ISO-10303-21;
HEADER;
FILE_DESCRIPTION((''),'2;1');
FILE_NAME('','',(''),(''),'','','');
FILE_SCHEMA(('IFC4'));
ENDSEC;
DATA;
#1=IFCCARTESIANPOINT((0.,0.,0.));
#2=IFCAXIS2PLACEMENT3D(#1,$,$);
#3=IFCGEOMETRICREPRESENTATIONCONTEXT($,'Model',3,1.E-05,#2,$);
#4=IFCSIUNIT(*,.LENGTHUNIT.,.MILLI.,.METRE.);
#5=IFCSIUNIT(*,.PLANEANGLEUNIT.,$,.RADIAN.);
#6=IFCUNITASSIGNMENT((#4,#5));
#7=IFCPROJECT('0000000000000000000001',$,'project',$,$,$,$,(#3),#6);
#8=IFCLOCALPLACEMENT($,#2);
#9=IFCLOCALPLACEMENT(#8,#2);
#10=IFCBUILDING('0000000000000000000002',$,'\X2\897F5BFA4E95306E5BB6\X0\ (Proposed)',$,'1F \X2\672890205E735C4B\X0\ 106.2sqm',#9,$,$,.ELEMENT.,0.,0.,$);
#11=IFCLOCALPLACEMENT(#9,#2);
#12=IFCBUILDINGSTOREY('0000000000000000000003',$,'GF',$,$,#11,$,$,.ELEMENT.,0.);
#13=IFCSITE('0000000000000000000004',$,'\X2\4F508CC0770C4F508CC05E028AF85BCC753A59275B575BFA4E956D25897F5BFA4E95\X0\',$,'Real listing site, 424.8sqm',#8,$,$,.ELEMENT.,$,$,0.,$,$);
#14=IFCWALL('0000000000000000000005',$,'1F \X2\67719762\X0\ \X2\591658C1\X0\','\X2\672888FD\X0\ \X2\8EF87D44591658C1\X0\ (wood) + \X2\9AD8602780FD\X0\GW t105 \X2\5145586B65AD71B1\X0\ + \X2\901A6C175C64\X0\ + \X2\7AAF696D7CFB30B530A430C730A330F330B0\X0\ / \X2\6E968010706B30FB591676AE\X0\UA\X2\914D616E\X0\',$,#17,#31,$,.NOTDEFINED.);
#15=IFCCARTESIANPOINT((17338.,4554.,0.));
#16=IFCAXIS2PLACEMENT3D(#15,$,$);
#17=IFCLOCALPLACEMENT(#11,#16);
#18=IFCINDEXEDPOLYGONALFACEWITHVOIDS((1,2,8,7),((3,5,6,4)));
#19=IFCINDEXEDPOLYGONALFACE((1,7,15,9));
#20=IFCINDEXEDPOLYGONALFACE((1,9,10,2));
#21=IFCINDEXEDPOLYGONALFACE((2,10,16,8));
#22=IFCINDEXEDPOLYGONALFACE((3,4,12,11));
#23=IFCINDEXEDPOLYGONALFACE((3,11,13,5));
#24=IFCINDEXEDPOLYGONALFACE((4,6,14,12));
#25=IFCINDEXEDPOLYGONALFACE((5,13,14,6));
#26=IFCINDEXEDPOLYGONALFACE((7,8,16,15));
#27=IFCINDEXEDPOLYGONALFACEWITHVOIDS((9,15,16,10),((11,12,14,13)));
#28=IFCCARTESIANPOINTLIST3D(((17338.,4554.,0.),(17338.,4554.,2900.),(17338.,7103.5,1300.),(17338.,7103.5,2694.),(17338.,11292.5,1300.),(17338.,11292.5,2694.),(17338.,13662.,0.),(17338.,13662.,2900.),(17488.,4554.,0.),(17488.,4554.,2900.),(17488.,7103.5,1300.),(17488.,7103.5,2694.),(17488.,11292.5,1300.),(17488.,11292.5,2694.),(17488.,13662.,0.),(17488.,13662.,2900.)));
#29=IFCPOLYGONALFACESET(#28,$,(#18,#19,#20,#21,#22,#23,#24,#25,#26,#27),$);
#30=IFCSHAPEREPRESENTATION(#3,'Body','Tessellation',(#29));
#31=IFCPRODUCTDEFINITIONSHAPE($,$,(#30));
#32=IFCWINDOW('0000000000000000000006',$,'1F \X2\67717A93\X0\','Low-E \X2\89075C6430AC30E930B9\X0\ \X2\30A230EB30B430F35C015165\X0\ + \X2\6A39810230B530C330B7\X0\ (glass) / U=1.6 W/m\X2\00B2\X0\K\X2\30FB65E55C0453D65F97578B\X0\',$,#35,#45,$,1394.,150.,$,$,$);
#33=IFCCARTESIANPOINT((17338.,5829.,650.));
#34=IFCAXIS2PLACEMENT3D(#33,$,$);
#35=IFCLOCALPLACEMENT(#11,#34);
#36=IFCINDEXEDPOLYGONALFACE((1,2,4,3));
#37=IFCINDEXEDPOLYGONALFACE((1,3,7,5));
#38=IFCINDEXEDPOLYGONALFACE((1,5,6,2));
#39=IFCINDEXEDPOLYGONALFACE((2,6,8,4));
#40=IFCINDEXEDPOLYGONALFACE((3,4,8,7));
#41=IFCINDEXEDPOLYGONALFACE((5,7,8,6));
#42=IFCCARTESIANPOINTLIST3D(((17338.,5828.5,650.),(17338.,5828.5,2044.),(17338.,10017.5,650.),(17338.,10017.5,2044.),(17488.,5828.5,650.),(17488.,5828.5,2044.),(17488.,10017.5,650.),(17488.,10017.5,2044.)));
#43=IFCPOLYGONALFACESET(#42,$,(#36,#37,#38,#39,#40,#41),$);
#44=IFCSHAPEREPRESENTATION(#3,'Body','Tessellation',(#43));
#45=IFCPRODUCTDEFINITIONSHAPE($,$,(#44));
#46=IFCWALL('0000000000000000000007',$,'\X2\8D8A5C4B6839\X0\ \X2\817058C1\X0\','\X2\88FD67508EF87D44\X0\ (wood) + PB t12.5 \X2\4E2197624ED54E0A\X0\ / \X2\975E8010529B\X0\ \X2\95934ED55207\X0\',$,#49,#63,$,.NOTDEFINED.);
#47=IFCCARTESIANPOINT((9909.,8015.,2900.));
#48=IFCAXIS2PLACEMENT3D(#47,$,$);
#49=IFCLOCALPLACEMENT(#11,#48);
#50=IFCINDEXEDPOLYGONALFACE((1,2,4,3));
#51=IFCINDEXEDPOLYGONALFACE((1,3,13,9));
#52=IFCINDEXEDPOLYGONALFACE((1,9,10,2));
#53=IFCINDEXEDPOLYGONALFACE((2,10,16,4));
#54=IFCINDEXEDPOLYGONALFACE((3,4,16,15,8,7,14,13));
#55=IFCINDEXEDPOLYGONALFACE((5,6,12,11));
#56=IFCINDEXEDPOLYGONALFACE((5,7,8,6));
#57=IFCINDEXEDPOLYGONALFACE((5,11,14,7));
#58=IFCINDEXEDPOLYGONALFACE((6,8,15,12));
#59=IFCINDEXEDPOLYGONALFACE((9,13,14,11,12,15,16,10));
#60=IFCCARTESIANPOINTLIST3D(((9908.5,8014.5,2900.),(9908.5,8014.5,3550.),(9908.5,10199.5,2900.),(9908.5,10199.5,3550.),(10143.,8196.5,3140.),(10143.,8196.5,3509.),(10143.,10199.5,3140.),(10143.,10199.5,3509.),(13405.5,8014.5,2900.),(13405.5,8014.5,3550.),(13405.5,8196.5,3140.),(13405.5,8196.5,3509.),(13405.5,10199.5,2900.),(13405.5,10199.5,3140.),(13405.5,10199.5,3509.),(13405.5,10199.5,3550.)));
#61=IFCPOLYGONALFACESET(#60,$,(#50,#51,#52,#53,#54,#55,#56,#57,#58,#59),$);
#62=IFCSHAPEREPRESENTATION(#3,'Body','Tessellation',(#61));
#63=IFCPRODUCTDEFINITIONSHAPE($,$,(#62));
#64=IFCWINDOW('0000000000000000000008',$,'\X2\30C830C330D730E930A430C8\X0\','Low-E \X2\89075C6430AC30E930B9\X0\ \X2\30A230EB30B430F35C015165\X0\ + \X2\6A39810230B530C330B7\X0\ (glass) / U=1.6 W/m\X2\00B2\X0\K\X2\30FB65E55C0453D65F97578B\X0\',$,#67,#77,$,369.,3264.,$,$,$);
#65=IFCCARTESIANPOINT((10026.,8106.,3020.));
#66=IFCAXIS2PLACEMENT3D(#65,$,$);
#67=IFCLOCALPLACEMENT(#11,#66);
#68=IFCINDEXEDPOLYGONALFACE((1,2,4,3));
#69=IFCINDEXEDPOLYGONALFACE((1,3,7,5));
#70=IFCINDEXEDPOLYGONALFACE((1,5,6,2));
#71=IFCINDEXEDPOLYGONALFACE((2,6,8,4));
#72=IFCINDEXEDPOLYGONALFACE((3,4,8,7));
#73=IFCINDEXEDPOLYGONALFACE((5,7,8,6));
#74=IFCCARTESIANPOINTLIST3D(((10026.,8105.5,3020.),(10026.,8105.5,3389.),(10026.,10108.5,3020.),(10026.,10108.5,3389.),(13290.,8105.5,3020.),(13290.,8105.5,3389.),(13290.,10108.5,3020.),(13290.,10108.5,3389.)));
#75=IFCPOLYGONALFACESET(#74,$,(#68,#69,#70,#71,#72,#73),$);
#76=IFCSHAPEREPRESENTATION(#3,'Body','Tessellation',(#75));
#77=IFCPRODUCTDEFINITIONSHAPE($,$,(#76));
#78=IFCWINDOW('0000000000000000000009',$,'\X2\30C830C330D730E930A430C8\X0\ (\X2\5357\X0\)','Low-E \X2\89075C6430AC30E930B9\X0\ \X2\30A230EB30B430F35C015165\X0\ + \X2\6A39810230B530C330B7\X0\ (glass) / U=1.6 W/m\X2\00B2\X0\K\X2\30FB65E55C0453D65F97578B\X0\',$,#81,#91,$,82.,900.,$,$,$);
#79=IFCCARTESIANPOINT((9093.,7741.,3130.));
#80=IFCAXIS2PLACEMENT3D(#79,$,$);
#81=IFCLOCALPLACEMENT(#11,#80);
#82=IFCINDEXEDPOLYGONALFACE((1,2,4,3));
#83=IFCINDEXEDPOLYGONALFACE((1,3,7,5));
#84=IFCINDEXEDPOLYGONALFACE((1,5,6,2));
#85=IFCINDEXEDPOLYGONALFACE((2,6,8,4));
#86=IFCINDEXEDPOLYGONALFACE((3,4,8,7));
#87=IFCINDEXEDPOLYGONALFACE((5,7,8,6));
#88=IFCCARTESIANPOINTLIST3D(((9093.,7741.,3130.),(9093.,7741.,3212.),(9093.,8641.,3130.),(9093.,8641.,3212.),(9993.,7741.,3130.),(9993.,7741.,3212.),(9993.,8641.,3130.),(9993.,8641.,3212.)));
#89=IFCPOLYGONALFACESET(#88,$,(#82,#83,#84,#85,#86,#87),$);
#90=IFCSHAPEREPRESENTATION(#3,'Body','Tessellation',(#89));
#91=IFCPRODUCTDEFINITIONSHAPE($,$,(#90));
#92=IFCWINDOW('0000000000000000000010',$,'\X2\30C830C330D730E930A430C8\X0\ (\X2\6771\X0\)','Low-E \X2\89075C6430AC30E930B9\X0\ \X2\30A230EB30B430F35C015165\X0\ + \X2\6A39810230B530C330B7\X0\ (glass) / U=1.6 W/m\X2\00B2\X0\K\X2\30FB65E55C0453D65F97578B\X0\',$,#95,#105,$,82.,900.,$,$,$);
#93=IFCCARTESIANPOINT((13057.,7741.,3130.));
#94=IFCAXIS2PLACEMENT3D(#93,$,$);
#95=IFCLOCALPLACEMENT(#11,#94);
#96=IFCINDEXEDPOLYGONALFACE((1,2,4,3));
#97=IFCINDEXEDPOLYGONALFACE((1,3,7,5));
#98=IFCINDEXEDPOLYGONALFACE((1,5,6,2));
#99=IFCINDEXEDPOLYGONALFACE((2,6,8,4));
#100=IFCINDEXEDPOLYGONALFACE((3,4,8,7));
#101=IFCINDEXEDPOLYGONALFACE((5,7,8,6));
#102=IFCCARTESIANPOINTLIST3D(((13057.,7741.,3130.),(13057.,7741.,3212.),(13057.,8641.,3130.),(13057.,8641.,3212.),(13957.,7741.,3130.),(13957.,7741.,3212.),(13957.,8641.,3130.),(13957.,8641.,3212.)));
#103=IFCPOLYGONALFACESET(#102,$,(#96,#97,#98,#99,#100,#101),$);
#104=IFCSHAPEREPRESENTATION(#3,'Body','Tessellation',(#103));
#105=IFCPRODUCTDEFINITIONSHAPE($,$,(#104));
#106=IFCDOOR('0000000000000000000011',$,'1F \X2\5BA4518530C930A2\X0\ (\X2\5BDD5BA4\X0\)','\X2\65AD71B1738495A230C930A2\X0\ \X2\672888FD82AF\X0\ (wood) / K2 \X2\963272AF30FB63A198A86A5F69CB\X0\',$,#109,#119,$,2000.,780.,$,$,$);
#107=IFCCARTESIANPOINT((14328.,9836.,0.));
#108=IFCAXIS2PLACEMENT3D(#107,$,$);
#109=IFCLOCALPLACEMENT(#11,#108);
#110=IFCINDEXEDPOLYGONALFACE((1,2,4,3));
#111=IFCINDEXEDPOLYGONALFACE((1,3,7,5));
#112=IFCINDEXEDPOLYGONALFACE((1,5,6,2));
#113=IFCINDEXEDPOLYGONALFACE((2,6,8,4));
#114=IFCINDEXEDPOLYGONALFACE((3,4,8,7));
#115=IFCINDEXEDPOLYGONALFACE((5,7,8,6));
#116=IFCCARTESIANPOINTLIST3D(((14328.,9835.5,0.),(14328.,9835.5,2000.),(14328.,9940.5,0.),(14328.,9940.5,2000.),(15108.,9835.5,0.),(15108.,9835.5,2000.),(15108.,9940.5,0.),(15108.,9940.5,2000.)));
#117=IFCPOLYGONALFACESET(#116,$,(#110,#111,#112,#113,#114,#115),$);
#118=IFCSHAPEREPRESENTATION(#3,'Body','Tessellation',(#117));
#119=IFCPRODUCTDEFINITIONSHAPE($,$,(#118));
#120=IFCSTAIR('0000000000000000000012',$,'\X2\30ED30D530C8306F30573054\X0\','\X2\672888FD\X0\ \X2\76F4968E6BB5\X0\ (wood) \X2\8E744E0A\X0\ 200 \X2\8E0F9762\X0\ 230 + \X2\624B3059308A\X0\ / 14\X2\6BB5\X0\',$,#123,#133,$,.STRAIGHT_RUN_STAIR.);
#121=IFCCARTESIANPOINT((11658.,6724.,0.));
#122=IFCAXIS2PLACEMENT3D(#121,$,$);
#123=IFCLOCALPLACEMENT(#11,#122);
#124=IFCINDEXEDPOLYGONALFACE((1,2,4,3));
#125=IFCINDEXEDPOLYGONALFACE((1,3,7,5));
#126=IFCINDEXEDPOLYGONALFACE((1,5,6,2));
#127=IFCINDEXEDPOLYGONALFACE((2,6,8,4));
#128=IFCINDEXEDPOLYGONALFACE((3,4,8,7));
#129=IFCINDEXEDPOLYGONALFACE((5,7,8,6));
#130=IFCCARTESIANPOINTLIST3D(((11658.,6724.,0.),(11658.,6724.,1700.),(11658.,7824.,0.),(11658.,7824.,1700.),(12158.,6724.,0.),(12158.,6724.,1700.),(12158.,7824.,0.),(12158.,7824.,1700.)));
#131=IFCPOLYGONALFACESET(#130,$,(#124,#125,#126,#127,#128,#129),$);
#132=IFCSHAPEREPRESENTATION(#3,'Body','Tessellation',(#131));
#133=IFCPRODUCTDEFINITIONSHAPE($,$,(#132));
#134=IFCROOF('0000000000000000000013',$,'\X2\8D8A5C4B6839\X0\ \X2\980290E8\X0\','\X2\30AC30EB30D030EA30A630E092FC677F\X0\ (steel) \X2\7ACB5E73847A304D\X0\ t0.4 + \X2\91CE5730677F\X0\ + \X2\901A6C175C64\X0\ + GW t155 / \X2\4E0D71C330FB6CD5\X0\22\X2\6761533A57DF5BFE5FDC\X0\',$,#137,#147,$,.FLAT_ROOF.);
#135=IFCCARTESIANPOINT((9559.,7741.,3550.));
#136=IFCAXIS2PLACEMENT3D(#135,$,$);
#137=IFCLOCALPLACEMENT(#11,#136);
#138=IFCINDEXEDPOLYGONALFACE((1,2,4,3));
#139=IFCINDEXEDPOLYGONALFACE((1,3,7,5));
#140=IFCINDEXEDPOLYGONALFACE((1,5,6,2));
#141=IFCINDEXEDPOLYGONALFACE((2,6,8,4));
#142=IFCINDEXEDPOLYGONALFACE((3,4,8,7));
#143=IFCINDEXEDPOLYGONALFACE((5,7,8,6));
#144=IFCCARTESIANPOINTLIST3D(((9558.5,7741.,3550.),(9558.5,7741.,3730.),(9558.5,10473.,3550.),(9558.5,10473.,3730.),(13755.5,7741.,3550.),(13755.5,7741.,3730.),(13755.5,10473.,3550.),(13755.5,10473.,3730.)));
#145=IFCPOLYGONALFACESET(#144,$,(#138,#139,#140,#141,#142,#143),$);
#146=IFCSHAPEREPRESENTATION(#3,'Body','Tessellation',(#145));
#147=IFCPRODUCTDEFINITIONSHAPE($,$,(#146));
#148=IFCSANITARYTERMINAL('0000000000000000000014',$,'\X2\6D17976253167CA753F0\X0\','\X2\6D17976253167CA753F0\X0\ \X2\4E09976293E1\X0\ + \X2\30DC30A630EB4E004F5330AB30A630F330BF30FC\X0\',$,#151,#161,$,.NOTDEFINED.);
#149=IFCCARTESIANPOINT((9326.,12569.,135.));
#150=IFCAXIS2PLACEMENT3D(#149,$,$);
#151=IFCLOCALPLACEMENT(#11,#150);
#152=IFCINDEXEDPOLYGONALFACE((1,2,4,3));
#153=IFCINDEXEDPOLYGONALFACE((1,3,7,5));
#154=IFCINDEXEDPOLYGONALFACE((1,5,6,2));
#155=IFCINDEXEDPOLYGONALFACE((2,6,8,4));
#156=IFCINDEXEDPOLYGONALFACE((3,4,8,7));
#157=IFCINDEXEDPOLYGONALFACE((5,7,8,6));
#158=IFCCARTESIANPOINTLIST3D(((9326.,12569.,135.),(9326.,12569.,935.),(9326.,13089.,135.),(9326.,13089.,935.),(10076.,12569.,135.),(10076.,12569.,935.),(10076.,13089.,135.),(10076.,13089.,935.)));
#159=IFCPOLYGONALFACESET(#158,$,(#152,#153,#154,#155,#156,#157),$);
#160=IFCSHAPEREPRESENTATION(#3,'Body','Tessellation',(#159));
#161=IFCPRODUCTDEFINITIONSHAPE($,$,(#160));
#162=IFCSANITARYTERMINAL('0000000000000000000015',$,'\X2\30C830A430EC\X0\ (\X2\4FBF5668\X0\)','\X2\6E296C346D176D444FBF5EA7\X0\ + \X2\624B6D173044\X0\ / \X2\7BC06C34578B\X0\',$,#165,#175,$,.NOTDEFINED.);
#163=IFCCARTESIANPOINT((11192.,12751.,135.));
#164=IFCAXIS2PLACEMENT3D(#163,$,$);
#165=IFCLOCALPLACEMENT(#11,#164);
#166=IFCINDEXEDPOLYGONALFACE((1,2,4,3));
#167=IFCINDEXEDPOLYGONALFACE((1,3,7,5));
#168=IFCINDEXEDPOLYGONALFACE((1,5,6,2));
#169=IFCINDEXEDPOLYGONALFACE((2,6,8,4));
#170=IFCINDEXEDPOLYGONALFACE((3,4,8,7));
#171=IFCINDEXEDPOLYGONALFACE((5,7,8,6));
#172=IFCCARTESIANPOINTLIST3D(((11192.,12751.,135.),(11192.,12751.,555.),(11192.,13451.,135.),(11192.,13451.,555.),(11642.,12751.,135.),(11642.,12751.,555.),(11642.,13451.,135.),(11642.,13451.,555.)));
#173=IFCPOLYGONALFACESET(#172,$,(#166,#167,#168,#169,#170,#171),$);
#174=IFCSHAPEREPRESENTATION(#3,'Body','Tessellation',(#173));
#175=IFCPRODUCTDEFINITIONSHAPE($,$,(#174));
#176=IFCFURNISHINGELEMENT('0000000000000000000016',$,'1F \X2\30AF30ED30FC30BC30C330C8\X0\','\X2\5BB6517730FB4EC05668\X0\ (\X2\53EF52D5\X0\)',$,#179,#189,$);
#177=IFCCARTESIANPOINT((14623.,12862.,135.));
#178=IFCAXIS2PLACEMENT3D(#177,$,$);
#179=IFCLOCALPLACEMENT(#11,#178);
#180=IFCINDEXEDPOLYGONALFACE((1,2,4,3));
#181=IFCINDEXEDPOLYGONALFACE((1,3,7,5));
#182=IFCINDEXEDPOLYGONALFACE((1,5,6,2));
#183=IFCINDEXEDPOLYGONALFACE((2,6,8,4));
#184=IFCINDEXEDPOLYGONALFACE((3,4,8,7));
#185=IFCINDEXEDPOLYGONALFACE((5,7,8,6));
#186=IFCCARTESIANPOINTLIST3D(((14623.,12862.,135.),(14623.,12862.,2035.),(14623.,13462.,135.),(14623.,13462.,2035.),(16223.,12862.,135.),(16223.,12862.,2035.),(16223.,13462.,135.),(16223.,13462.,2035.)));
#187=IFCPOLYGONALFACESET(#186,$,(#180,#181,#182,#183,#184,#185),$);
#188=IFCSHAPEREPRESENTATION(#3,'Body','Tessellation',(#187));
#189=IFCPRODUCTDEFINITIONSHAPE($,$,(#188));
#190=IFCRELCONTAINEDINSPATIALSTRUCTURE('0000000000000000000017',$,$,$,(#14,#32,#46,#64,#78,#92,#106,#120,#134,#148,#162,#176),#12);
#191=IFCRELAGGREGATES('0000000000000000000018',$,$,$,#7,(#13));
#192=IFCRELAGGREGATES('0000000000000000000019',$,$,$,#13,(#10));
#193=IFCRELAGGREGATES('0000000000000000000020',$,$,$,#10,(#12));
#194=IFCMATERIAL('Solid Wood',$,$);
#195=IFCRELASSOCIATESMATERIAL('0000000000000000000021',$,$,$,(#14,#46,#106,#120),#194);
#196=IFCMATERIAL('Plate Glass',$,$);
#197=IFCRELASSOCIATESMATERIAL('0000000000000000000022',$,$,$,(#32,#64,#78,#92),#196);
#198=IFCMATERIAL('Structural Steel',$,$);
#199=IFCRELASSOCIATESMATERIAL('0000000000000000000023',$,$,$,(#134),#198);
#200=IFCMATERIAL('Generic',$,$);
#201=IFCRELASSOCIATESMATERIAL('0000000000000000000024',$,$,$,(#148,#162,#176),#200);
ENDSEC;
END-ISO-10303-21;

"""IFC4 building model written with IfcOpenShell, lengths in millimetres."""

from ifc_helpers import new_model, si_unit, frame, frame_2d, origin, place, context, project, spatial, rectangle, extrude, material, element, fill, save


model = new_model("IFC4")

# Units and contexts
model_context = context("Model", 3, precision=1e-05, world=origin())
ifc_project = project(units=[si_unit("LENGTHUNIT", "METRE", prefix="MILLI"), si_unit("PLANEANGLEUNIT", "RADIAN")], contexts=[model_context])

# Site, building, storey
site_placement = place(None, origin())
site = spatial("IfcSite", under=ifc_project, at=site_placement, Name="佐賀県佐賀市諸富町大字寺井津西寺井", ObjectType="Real listing site, 424.8sqm", CompositionType="ELEMENT", RefElevation=0.0)
building_placement = place(site_placement, origin())
building = spatial("IfcBuilding", under=site, at=building_placement, Name="西寺井の家 (Proposed)", ObjectType="1F 木造平屋 106.2sqm", CompositionType="ELEMENT", ElevationOfRefHeight=0.0, ElevationOfTerrain=0.0)
storey_placement = place(building_placement, origin())
storey = spatial("IfcBuildingStorey", under=building, at=storey_placement, Name="GF", CompositionType="ELEMENT", Elevation=0.0)

# Wall, opening, window
ifc_material_1 = material(Name="Solid Wood")
wall_1_placement = place(storey_placement, frame((17338.0, 4554.0, 0.0)))
wall_1 = element("IfcWall", 1, at=wall_1_placement, inside=storey, material=ifc_material_1, Name="1F 東面 外壁", Description="木製 軸組外壁 (wood) + 高性能GW t105 充填断熱 + 通気層 + 窯業系サイディング / 準耐火・外皮UA配慮", PredefinedType="NOTDEFINED", context=model_context, shape_type="SweptSolid", body=[
    extrude(rectangle(XDim=150.0, YDim=9108.0, at=frame_2d((75.0, 4554.0))), frame((17338.0, 4554.0, 0.0)), (0.0, 0.0, 1.0), 2900.0),
])
opening_1_placement = place(storey_placement, frame((17338.0, 5829.0, 650.0)))
opening_1 = element("IfcOpeningElement", 2, at=opening_1_placement, cuts=wall_1, PredefinedType="NOTDEFINED", context=model_context, shape_type="SweptSolid", body=[
    extrude(rectangle(XDim=150.0, YDim=4189.0, at=frame_2d((75.0, 2094.0))), frame((17338.0, 5829.0, 650.0)), (0.0, 0.0, 1.0), 1394.0),
])
ifc_material_2 = material(Name="Plate Glass")
window_1_placement = place(storey_placement, frame((17338.0, 5829.0, 650.0)))
window_1 = element("IfcWindow", 3, at=window_1_placement, inside=storey, material=ifc_material_2, Name="1F 東窓", Description="Low-E 複層ガラス アルゴン封入 + 樹脂サッシ (glass) / U=1.6 W/m²K・日射取得型", OverallHeight=1394.0, OverallWidth=150.0, context=model_context, shape_type="SweptSolid", body=[
    extrude(rectangle(XDim=150.0, YDim=4189.0, at=frame_2d((75.0, 2094.0))), frame((17338.0, 5829.0, 650.0)), (0.0, 0.0, 1.0), 1394.0),
])
fill(opening_1, window_1)

# Wall, openings, windows
wall_2_placement = place(storey_placement, frame((9909.0, 8015.0, 2900.0)))
wall_2 = element("IfcWall", 4, at=wall_2_placement, inside=storey, material=ifc_material_1, Name="越屋根 腰壁", Description="製材軸組 (wood) + PB t12.5 両面仕上 / 非耐力 間仕切", PredefinedType="NOTDEFINED", context=model_context, shape_type="SweptSolid", body=[
    extrude(rectangle(XDim=3497.0, YDim=2185.0, at=frame_2d((1748.0, 1092.0))), frame((9909.0, 8015.0, 2900.0)), (0.0, 0.0, 1.0), 650.0),
])
opening_2_placement = place(storey_placement, frame((10026.0, 8106.0, 3020.0)))
opening_2 = element("IfcOpeningElement", 5, at=opening_2_placement, cuts=wall_2, PredefinedType="NOTDEFINED", context=model_context, shape_type="SweptSolid", body=[
    extrude(rectangle(XDim=3264.0, YDim=2003.0, at=frame_2d((1632.0, 1001.0))), frame((10026.0, 8106.0, 3020.0)), (0.0, 0.0, 1.0), 369.0),
])
opening_3_placement = place(storey_placement, frame((9093.0, 7741.0, 3130.0)))
opening_3 = element("IfcOpeningElement", 6, at=opening_3_placement, cuts=wall_2, PredefinedType="NOTDEFINED", context=model_context, shape_type="SweptSolid", body=[
    extrude(rectangle(XDim=900.0, YDim=900.0, at=frame_2d((450.0, 450.0))), frame((9093.0, 7741.0, 3130.0)), (0.0, 0.0, 1.0), 82.0),
])
opening_4_placement = place(storey_placement, frame((13057.0, 7741.0, 3130.0)))
opening_4 = element("IfcOpeningElement", 7, at=opening_4_placement, cuts=wall_2, PredefinedType="NOTDEFINED", context=model_context, shape_type="SweptSolid", body=[
    extrude(rectangle(XDim=900.0, YDim=900.0, at=frame_2d((450.0, 450.0))), frame((13057.0, 7741.0, 3130.0)), (0.0, 0.0, 1.0), 82.0),
])
window_2_placement = place(storey_placement, frame((10026.0, 8106.0, 3020.0)))
window_2 = element("IfcWindow", 8, at=window_2_placement, inside=storey, material=ifc_material_2, Name="トップライト", Description="Low-E 複層ガラス アルゴン封入 + 樹脂サッシ (glass) / U=1.6 W/m²K・日射取得型", OverallHeight=369.0, OverallWidth=3264.0, context=model_context, shape_type="SweptSolid", body=[
    extrude(rectangle(XDim=3264.0, YDim=2003.0, at=frame_2d((1632.0, 1001.0))), frame((10026.0, 8106.0, 3020.0)), (0.0, 0.0, 1.0), 369.0),
])
fill(opening_2, window_2)
window_3_placement = place(storey_placement, frame((9093.0, 7741.0, 3130.0)))
window_3 = element("IfcWindow", 9, at=window_3_placement, inside=storey, material=ifc_material_2, Name="トップライト (南)", Description="Low-E 複層ガラス アルゴン封入 + 樹脂サッシ (glass) / U=1.6 W/m²K・日射取得型", OverallHeight=82.0, OverallWidth=900.0, context=model_context, shape_type="SweptSolid", body=[
    extrude(rectangle(XDim=900.0, YDim=900.0, at=frame_2d((450.0, 450.0))), frame((9093.0, 7741.0, 3130.0)), (0.0, 0.0, 1.0), 82.0),
])
fill(opening_3, window_3)
window_4_placement = place(storey_placement, frame((13057.0, 7741.0, 3130.0)))
window_4 = element("IfcWindow", 10, at=window_4_placement, inside=storey, material=ifc_material_2, Name="トップライト (東)", Description="Low-E 複層ガラス アルゴン封入 + 樹脂サッシ (glass) / U=1.6 W/m²K・日射取得型", OverallHeight=82.0, OverallWidth=900.0, context=model_context, shape_type="SweptSolid", body=[
    extrude(rectangle(XDim=900.0, YDim=900.0, at=frame_2d((450.0, 450.0))), frame((13057.0, 7741.0, 3130.0)), (0.0, 0.0, 1.0), 82.0),
])
fill(opening_4, window_4)

# Door
door_placement = place(storey_placement, frame((14328.0, 9836.0, 0.0)))
element("IfcDoor", 11, at=door_placement, inside=storey, material=ifc_material_1, Name="1F 室内ドア (寝室)", Description="断熱玄関ドア 木製芯 (wood) / K2 防犯・採風機構", OverallHeight=2000.0, OverallWidth=780.0, context=model_context, shape_type="SweptSolid", body=[
    extrude(rectangle(XDim=780.0, YDim=105.0, at=frame_2d((390.0, 52.0))), frame((14328.0, 9836.0, 0.0)), (0.0, 0.0, 1.0), 2000.0),
])

# Stair
stair_placement = place(storey_placement, frame((11658.0, 6724.0, 0.0)))
element("IfcStair", 12, at=stair_placement, inside=storey, material=ifc_material_1, Name="ロフトはしご", Description="木製 直階段 (wood) 蹴上 200 踏面 230 + 手すり / 14段", PredefinedType="STRAIGHT_RUN_STAIR", context=model_context, shape_type="SweptSolid", body=[
    extrude(rectangle(XDim=500.0, YDim=1100.0, at=frame_2d((250.0, 550.0))), frame((11658.0, 6724.0, 0.0)), (0.0, 0.0, 1.0), 1700.0),
])

# Roof
ifc_material_3 = material(Name="Structural Steel")
roof_placement = place(storey_placement, frame((9559.0, 7741.0, 3550.0)))
element("IfcRoof", 13, at=roof_placement, inside=storey, material=ifc_material_3, Name="越屋根 頂部", Description="ガルバリウム鋼板 (steel) 立平葺き t0.4 + 野地板 + 通気層 + GW t155 / 不燃・法22条区域対応", PredefinedType="FLAT_ROOF", context=model_context, shape_type="SweptSolid", body=[
    extrude(rectangle(XDim=4197.0, YDim=2732.0, at=frame_2d((2098.0, 1366.0))), frame((9559.0, 7741.0, 3550.0)), (0.0, 0.0, 1.0), 180.0),
])

# Sanitary terminals
ifc_material_4 = material(Name="Generic")
sanitary_terminal_1_placement = place(storey_placement, frame((9326.0, 12569.0, 135.0)))
element("IfcSanitaryTerminal", 14, at=sanitary_terminal_1_placement, inside=storey, material=ifc_material_4, Name="洗面化粧台", Description="洗面化粧台 三面鏡 + ボウル一体カウンター", PredefinedType="NOTDEFINED", context=model_context, shape_type="SweptSolid", body=[
    extrude(rectangle(XDim=750.0, YDim=520.0, at=frame_2d((375.0, 260.0))), frame((9326.0, 12569.0, 135.0)), (0.0, 0.0, 1.0), 800.0),
])
sanitary_terminal_2_placement = place(storey_placement, frame((11192.0, 12751.0, 135.0)))
element("IfcSanitaryTerminal", 15, at=sanitary_terminal_2_placement, inside=storey, material=ifc_material_4, Name="トイレ (便器)", Description="温水洗浄便座 + 手洗い / 節水型", PredefinedType="NOTDEFINED", context=model_context, shape_type="SweptSolid", body=[
    extrude(rectangle(XDim=450.0, YDim=700.0, at=frame_2d((225.0, 350.0))), frame((11192.0, 12751.0, 135.0)), (0.0, 0.0, 1.0), 420.0),
])

# Furnishing element
furnishing_1_placement = place(storey_placement, frame((14623.0, 12862.0, 135.0)))
element("IfcFurnishingElement", 16, at=furnishing_1_placement, inside=storey, material=ifc_material_4, Name="1F クローゼット", Description="家具・什器 (可動)", context=model_context, shape_type="SweptSolid", body=[
    extrude(rectangle(XDim=1600.0, YDim=600.0, at=frame_2d((800.0, 300.0))), frame((14623.0, 12862.0, 135.0)), (0.0, 0.0, 1.0), 1900.0),
])

save(model, "model.ifc")
